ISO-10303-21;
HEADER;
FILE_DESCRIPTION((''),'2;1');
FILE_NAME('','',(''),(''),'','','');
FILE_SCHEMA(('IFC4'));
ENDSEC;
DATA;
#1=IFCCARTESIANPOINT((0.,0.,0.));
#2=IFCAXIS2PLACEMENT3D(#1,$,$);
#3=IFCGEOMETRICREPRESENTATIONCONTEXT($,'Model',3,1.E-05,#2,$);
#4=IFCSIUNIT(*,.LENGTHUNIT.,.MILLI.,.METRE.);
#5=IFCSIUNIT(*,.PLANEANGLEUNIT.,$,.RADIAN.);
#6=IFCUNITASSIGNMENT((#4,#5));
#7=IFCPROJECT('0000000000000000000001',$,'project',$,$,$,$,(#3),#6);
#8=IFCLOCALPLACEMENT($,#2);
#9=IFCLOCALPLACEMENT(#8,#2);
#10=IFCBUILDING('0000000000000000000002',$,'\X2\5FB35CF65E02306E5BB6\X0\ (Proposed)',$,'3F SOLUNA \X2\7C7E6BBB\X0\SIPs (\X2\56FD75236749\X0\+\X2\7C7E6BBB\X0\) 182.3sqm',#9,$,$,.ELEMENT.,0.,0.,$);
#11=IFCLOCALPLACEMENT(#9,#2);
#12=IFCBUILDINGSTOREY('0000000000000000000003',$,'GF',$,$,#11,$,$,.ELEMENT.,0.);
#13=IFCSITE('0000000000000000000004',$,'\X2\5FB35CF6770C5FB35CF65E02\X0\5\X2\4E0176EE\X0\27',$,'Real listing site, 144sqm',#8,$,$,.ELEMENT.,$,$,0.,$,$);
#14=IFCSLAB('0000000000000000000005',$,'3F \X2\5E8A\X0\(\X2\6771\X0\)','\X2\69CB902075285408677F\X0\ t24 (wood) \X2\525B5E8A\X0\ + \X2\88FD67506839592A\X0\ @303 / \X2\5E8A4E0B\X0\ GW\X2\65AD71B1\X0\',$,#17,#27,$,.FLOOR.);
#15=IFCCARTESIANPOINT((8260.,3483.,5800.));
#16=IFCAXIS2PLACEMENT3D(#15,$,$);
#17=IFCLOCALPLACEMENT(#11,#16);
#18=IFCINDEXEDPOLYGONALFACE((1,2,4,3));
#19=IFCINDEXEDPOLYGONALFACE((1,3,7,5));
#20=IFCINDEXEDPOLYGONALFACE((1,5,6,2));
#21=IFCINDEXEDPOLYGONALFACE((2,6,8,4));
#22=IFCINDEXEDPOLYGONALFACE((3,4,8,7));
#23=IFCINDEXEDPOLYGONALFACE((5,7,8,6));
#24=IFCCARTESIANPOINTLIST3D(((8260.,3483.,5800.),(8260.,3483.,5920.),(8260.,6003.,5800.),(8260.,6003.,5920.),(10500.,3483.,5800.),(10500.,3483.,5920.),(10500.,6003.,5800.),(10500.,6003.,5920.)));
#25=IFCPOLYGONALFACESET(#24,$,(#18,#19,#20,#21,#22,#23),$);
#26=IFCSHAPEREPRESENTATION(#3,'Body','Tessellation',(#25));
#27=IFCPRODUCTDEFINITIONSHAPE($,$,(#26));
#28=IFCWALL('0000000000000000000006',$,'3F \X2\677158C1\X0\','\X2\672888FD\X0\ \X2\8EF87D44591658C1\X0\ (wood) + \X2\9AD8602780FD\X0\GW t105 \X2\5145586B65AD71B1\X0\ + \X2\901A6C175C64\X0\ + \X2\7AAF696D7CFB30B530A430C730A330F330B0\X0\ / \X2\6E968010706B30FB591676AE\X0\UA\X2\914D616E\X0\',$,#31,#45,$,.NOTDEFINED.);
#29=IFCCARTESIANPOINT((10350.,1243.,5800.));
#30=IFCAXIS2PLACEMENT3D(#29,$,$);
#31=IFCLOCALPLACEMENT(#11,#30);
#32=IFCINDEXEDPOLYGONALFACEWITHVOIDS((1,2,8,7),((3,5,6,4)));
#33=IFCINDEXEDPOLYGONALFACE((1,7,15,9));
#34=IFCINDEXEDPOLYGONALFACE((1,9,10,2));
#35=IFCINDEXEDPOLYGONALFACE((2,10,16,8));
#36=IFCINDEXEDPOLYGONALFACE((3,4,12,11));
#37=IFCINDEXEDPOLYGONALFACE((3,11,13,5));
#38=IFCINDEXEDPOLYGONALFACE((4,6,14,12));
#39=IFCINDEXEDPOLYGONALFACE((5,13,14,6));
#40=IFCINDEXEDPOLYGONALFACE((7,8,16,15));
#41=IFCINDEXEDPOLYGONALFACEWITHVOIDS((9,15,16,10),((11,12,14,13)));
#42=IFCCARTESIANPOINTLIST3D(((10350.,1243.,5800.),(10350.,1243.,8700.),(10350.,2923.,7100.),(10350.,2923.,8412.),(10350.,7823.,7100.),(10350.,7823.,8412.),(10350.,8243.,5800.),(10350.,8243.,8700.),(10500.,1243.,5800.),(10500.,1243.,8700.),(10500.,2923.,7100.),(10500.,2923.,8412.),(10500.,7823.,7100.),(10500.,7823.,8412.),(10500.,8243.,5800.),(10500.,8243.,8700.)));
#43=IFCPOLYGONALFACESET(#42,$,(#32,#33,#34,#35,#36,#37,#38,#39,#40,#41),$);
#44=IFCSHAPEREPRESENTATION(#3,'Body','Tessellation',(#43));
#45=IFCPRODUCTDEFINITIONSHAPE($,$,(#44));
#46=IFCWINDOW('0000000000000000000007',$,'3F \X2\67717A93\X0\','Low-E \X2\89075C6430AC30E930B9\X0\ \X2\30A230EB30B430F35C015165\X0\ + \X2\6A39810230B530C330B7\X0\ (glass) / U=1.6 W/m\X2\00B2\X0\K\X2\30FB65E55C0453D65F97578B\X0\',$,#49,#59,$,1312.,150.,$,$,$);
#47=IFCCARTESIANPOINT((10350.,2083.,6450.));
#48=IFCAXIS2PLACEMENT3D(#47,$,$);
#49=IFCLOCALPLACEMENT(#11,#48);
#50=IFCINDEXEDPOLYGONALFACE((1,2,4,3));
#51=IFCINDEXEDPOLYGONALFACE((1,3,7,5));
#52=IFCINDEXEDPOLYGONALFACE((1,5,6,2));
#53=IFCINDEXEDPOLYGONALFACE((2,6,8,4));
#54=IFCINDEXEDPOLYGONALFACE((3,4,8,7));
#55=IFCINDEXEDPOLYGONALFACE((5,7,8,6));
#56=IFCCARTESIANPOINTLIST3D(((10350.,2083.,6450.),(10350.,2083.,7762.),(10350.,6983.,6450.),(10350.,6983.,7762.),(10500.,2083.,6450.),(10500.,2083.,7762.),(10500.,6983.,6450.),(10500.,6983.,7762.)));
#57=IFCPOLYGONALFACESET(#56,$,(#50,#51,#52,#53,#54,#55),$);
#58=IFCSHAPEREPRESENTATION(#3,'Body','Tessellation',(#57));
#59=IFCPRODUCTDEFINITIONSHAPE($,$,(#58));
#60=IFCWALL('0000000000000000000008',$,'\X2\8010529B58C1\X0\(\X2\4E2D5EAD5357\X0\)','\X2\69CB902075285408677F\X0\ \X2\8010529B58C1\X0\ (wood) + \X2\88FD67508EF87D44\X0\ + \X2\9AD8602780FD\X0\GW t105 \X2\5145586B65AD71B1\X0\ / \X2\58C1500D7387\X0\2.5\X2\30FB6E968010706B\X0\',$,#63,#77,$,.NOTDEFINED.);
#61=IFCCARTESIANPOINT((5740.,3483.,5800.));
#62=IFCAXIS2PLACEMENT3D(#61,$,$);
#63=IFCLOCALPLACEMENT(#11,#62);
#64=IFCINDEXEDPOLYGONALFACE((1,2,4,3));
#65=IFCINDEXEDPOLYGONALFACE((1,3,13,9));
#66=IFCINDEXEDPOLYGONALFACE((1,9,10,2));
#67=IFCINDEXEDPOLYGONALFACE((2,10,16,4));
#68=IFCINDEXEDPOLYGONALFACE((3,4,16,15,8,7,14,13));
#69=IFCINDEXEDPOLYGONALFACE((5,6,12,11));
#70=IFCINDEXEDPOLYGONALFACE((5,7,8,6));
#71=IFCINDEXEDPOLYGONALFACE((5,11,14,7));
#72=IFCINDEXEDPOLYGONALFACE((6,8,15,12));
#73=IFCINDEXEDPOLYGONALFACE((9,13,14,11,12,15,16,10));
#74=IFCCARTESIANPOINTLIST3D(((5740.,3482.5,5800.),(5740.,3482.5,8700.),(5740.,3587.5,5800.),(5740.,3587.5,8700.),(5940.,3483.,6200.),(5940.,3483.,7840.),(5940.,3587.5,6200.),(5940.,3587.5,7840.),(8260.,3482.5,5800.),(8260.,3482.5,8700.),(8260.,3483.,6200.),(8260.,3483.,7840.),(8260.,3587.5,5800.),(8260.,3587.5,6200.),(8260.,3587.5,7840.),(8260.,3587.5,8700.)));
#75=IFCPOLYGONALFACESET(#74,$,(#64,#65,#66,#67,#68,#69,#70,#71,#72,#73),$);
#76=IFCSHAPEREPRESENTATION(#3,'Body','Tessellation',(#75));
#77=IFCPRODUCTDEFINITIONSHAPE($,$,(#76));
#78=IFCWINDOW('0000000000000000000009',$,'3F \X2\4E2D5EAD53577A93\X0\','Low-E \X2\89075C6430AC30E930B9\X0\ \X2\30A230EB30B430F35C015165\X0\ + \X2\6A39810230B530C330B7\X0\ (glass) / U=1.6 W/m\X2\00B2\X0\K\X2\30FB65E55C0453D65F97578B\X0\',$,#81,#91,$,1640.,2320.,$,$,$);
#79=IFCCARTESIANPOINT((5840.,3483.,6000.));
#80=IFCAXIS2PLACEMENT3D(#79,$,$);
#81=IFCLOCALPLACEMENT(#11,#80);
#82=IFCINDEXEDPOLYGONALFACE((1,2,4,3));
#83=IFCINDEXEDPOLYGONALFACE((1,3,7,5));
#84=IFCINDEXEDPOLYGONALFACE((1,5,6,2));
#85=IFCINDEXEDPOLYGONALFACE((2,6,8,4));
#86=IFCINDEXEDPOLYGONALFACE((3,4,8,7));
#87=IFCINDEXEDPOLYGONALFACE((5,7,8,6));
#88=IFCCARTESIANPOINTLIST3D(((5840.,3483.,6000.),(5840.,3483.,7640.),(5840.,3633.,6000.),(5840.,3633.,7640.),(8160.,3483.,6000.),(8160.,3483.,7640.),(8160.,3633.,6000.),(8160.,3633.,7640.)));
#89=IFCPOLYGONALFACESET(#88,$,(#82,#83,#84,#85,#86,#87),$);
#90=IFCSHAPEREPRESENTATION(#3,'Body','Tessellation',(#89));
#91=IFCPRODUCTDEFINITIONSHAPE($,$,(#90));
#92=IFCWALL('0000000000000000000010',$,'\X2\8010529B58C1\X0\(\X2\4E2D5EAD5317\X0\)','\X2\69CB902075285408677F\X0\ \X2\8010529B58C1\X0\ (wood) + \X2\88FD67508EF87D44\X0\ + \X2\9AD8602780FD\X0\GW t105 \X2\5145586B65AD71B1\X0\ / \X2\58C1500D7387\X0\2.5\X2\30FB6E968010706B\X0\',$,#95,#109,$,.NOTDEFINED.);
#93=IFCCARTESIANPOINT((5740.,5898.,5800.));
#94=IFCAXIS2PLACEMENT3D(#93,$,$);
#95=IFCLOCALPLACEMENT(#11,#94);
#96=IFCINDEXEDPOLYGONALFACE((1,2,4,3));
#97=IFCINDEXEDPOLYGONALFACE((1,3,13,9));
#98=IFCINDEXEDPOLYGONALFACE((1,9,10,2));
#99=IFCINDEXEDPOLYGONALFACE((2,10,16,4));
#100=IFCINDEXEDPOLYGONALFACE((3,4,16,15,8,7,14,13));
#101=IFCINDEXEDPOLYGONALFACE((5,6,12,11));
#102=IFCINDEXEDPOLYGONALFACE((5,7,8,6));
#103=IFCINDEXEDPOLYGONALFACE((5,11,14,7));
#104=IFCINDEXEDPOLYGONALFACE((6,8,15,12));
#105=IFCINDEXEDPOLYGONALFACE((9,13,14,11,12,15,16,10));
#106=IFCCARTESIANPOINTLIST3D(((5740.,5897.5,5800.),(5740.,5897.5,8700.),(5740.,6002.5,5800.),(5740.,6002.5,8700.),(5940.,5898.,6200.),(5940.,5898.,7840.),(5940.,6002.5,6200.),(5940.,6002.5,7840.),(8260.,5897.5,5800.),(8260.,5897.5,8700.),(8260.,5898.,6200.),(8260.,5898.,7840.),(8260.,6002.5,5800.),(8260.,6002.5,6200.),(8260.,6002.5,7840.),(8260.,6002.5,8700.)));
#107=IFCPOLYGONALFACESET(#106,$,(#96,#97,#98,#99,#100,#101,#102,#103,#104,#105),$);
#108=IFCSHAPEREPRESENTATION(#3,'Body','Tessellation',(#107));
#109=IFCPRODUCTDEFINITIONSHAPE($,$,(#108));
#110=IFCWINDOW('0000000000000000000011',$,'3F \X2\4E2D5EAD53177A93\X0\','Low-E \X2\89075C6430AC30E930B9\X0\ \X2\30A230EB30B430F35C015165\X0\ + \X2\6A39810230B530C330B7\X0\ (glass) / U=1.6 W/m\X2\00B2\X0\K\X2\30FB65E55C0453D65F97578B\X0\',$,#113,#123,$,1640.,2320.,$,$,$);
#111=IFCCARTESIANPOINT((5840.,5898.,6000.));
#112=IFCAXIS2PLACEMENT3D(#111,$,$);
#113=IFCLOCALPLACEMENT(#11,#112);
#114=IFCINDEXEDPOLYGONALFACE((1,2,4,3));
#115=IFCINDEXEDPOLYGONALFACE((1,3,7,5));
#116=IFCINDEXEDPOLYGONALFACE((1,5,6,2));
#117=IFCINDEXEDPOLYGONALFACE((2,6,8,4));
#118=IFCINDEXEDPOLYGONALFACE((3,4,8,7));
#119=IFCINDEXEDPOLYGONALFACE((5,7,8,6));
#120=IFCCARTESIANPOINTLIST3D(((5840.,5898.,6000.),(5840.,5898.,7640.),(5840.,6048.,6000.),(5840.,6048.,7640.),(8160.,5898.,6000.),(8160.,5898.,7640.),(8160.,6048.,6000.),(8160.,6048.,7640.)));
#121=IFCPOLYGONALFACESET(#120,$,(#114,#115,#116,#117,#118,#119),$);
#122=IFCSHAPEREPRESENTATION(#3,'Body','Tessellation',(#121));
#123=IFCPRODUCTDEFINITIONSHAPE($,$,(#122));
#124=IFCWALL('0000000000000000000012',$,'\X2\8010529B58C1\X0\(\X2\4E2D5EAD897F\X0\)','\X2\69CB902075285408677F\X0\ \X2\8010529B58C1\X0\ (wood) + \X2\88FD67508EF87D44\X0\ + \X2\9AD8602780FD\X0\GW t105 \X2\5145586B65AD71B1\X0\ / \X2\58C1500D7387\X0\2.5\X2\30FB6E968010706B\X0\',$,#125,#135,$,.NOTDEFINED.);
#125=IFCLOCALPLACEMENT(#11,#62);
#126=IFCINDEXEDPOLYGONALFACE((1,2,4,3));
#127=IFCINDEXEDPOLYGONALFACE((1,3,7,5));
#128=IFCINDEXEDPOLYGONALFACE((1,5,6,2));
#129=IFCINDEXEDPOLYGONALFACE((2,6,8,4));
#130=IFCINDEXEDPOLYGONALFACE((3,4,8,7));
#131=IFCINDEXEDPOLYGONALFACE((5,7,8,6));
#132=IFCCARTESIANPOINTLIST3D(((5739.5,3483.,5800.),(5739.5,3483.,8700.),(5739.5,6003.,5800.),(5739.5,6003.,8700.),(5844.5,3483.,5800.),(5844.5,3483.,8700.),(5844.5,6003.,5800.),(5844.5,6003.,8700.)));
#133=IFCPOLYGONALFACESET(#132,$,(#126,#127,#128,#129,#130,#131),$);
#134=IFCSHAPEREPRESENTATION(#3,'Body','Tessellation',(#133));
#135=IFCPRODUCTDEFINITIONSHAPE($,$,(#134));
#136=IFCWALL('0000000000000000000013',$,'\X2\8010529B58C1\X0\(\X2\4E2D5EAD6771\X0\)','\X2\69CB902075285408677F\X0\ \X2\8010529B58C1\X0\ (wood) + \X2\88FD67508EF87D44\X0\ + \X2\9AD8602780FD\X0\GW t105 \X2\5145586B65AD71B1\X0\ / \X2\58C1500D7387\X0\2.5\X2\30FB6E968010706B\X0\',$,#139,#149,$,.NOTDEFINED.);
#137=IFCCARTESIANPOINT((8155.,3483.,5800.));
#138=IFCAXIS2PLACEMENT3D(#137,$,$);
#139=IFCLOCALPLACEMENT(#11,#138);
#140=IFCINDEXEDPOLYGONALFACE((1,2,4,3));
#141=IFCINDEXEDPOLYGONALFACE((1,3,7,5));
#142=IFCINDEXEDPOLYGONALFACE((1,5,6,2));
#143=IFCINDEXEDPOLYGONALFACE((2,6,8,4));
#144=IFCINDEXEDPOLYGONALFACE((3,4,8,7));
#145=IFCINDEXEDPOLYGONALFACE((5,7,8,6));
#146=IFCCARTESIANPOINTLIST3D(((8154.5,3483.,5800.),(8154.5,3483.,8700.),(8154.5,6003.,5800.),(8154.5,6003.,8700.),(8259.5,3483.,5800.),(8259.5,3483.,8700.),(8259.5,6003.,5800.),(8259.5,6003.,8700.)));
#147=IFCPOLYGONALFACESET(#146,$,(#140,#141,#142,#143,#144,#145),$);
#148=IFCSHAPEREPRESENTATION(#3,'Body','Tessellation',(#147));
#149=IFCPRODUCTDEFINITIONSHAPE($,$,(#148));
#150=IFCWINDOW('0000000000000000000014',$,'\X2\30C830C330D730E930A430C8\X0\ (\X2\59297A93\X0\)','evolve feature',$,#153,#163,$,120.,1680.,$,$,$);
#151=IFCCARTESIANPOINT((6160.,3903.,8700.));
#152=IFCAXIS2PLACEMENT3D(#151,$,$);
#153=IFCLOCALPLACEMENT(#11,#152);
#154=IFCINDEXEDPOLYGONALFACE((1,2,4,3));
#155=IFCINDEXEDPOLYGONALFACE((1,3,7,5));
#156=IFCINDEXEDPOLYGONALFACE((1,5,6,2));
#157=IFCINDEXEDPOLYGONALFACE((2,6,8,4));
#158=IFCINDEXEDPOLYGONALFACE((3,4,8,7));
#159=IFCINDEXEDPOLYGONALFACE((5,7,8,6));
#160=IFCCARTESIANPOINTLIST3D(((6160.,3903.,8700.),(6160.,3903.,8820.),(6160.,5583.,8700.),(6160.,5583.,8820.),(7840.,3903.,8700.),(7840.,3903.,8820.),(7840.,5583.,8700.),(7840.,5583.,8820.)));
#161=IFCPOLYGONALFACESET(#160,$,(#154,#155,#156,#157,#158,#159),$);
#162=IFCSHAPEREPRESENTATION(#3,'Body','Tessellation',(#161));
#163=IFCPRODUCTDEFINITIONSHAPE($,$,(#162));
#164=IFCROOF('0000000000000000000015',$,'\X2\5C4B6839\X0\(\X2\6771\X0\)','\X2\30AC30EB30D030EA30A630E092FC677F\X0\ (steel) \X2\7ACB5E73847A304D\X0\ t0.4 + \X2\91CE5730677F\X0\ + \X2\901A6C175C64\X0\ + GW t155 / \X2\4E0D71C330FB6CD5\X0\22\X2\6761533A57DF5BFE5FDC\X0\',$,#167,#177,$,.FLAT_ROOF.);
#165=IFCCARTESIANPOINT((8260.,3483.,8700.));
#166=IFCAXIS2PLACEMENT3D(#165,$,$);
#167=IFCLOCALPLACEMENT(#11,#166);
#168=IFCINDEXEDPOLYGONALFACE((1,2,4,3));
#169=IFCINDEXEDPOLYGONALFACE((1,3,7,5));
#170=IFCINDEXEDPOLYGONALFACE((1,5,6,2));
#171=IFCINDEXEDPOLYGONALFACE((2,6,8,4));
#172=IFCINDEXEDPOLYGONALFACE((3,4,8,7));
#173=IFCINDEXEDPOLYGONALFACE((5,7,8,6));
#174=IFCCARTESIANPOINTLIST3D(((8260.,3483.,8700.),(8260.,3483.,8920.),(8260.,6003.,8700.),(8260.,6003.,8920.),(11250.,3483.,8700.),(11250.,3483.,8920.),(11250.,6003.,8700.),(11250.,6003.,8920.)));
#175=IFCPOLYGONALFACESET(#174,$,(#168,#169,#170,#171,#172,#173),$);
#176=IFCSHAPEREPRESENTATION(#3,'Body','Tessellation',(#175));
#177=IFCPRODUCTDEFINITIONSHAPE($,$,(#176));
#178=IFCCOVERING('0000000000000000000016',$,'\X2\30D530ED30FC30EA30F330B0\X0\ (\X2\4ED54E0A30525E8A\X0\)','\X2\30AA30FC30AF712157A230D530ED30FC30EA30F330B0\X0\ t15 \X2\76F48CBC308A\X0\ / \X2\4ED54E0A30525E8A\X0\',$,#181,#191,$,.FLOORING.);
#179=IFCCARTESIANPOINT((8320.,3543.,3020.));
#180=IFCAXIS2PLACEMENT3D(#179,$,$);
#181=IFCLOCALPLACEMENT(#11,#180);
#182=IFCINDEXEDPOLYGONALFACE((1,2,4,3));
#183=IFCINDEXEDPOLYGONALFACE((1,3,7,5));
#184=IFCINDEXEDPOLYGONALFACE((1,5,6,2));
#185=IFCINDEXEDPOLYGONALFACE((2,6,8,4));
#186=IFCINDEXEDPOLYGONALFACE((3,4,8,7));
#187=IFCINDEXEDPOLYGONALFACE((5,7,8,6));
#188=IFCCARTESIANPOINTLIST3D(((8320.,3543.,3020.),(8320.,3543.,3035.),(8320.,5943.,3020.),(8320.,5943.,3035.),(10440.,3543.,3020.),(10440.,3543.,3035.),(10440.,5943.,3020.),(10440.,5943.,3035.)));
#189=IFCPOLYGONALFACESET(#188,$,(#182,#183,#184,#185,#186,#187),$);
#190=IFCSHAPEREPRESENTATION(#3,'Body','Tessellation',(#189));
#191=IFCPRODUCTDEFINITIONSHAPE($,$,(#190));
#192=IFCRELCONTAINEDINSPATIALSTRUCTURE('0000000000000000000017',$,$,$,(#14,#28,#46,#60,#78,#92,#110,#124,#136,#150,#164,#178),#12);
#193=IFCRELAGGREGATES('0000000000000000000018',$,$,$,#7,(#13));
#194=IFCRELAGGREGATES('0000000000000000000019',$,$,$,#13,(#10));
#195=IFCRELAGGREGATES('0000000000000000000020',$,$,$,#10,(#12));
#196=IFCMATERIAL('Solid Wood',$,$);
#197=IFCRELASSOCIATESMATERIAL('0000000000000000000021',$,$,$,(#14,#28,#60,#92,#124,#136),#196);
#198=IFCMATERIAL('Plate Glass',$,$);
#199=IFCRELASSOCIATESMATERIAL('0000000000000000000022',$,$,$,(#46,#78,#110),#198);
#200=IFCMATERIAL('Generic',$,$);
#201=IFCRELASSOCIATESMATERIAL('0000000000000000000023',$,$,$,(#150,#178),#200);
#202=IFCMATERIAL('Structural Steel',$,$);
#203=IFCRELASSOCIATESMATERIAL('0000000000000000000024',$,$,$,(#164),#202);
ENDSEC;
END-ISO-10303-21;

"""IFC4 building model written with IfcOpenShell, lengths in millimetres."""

from ifc_helpers import new_model, si_unit, frame, frame_2d, origin, place, context, project, spatial, rectangle, extrude, material, element, fill, save


model = new_model("IFC4")

# Units and contexts
model_context = context("Model", 3, precision=1e-05, world=origin())
ifc_project = project(units=[si_unit("LENGTHUNIT", "METRE", prefix="MILLI"), si_unit("PLANEANGLEUNIT", "RADIAN")], contexts=[model_context])

# Site, building, storey
site_placement = place(None, origin())
site = spatial("IfcSite", under=ifc_project, at=site_placement, Name="徳島県徳島市5丁目27", ObjectType="Real listing site, 144sqm", CompositionType="ELEMENT", RefElevation=0.0)
building_placement = place(site_placement, origin())
building = spatial("IfcBuilding", under=site, at=building_placement, Name="徳島市の家 (Proposed)", ObjectType="3F SOLUNA 籾殻SIPs (国産杉+籾殻) 182.3sqm", CompositionType="ELEMENT", ElevationOfRefHeight=0.0, ElevationOfTerrain=0.0)
storey_placement = place(building_placement, origin())
storey = spatial("IfcBuildingStorey", under=building, at=storey_placement, Name="GF", CompositionType="ELEMENT", Elevation=0.0)

# Slab
ifc_material_1 = material(Name="Solid Wood")
slab_placement = place(storey_placement, frame((8260.0, 3483.0, 5800.0)))
element("IfcSlab", 1, at=slab_placement, inside=storey, material=ifc_material_1, Name="3F 床(東)", Description="構造用合板 t24 (wood) 剛床 + 製材根太 @303 / 床下 GW断熱", PredefinedType="FLOOR", context=model_context, shape_type="SweptSolid", body=[
    extrude(rectangle(XDim=2240.0, YDim=2520.0, at=frame_2d((1120.0, 1260.0))), frame((8260.0, 3483.0, 5800.0)), (0.0, 0.0, 1.0), 120.0),
])

# Walls, openings, windows
wall_1_placement = place(storey_placement, frame((10350.0, 1243.0, 5800.0)))
wall_1 = element("IfcWall", 2, at=wall_1_placement, inside=storey, material=ifc_material_1, Name="3F 東壁", Description="木製 軸組外壁 (wood) + 高性能GW t105 充填断熱 + 通気層 + 窯業系サイディング / 準耐火・外皮UA配慮", PredefinedType="NOTDEFINED", context=model_context, shape_type="SweptSolid", body=[
    extrude(rectangle(XDim=150.0, YDim=7000.0, at=frame_2d((75.0, 3500.0))), frame((10350.0, 1243.0, 5800.0)), (0.0, 0.0, 1.0), 2900.0),
])
opening_1_placement = place(storey_placement, frame((10350.0, 2083.0, 6450.0)))
opening_1 = element("IfcOpeningElement", 3, at=opening_1_placement, cuts=wall_1, PredefinedType="NOTDEFINED", context=model_context, shape_type="SweptSolid", body=[
    extrude(rectangle(XDim=150.0, YDim=4900.0, at=frame_2d((75.0, 2450.0))), frame((10350.0, 2083.0, 6450.0)), (0.0, 0.0, 1.0), 1312.0),
])
ifc_material_2 = material(Name="Plate Glass")
window_1_placement = place(storey_placement, frame((10350.0, 2083.0, 6450.0)))
window_1 = element("IfcWindow", 4, at=window_1_placement, inside=storey, material=ifc_material_2, Name="3F 東窓", Description="Low-E 複層ガラス アルゴン封入 + 樹脂サッシ (glass) / U=1.6 W/m²K・日射取得型", OverallHeight=1312.0, OverallWidth=150.0, context=model_context, shape_type="SweptSolid", body=[
    extrude(rectangle(XDim=150.0, YDim=4900.0, at=frame_2d((75.0, 2450.0))), frame((10350.0, 2083.0, 6450.0)), (0.0, 0.0, 1.0), 1312.0),
])
fill(opening_1, window_1)
wall_2_placement = place(storey_placement, frame((5740.0, 3483.0, 5800.0)))
wall_2 = element("IfcWall", 5, at=wall_2_placement, inside=storey, material=ifc_material_1, Name="耐力壁(中庭南)", Description="構造用合板 耐力壁 (wood) + 製材軸組 + 高性能GW t105 充填断熱 / 壁倍率2.5・準耐火", PredefinedType="NOTDEFINED", context=model_context, shape_type="SweptSolid", body=[
    extrude(rectangle(XDim=2520.0, YDim=105.0, at=frame_2d((1260.0, 52.0))), frame((5740.0, 3483.0, 5800.0)), (0.0, 0.0, 1.0), 2900.0),
])
opening_2_placement = place(storey_placement, frame((5840.0, 3483.0, 6000.0)))
opening_2 = element("IfcOpeningElement", 6, at=opening_2_placement, cuts=wall_2, PredefinedType="NOTDEFINED", context=model_context, shape_type="SweptSolid", body=[
    extrude(rectangle(XDim=2320.0, YDim=150.0, at=frame_2d((1160.0, 75.0))), frame((5840.0, 3483.0, 6000.0)), (0.0, 0.0, 1.0), 1640.0),
])
window_2_placement = place(storey_placement, frame((5840.0, 3483.0, 6000.0)))
window_2 = element("IfcWindow", 7, at=window_2_placement, inside=storey, material=ifc_material_2, Name="3F 中庭南窓", Description="Low-E 複層ガラス アルゴン封入 + 樹脂サッシ (glass) / U=1.6 W/m²K・日射取得型", OverallHeight=1640.0, OverallWidth=2320.0, context=model_context, shape_type="SweptSolid", body=[
    extrude(rectangle(XDim=2320.0, YDim=150.0, at=frame_2d((1160.0, 75.0))), frame((5840.0, 3483.0, 6000.0)), (0.0, 0.0, 1.0), 1640.0),
])
fill(opening_2, window_2)
wall_3_placement = place(storey_placement, frame((5740.0, 5898.0, 5800.0)))
wall_3 = element("IfcWall", 8, at=wall_3_placement, inside=storey, material=ifc_material_1, Name="耐力壁(中庭北)", Description="構造用合板 耐力壁 (wood) + 製材軸組 + 高性能GW t105 充填断熱 / 壁倍率2.5・準耐火", PredefinedType="NOTDEFINED", context=model_context, shape_type="SweptSolid", body=[
    extrude(rectangle(XDim=2520.0, YDim=105.0, at=frame_2d((1260.0, 52.0))), frame((5740.0, 5898.0, 5800.0)), (0.0, 0.0, 1.0), 2900.0),
])
opening_3_placement = place(storey_placement, frame((5840.0, 5898.0, 6000.0)))
opening_3 = element("IfcOpeningElement", 9, at=opening_3_placement, cuts=wall_3, PredefinedType="NOTDEFINED", context=model_context, shape_type="SweptSolid", body=[
    extrude(rectangle(XDim=2320.0, YDim=150.0, at=frame_2d((1160.0, 75.0))), frame((5840.0, 5898.0, 6000.0)), (0.0, 0.0, 1.0), 1640.0),
])
window_3_placement = place(storey_placement, frame((5840.0, 5898.0, 6000.0)))
window_3 = element("IfcWindow", 10, at=window_3_placement, inside=storey, material=ifc_material_2, Name="3F 中庭北窓", Description="Low-E 複層ガラス アルゴン封入 + 樹脂サッシ (glass) / U=1.6 W/m²K・日射取得型", OverallHeight=1640.0, OverallWidth=2320.0, context=model_context, shape_type="SweptSolid", body=[
    extrude(rectangle(XDim=2320.0, YDim=150.0, at=frame_2d((1160.0, 75.0))), frame((5840.0, 5898.0, 6000.0)), (0.0, 0.0, 1.0), 1640.0),
])
fill(opening_3, window_3)

# Walls
wall_4_placement = place(storey_placement, frame((5740.0, 3483.0, 5800.0)))
element("IfcWall", 11, at=wall_4_placement, inside=storey, material=ifc_material_1, Name="耐力壁(中庭西)", Description="構造用合板 耐力壁 (wood) + 製材軸組 + 高性能GW t105 充填断熱 / 壁倍率2.5・準耐火", PredefinedType="NOTDEFINED", context=model_context, shape_type="SweptSolid", body=[
    extrude(rectangle(XDim=105.0, YDim=2520.0, at=frame_2d((52.0, 1260.0))), frame((5740.0, 3483.0, 5800.0)), (0.0, 0.0, 1.0), 2900.0),
])
wall_5_placement = place(storey_placement, frame((8155.0, 3483.0, 5800.0)))
element("IfcWall", 12, at=wall_5_placement, inside=storey, material=ifc_material_1, Name="耐力壁(中庭東)", Description="構造用合板 耐力壁 (wood) + 製材軸組 + 高性能GW t105 充填断熱 / 壁倍率2.5・準耐火", PredefinedType="NOTDEFINED", context=model_context, shape_type="SweptSolid", body=[
    extrude(rectangle(XDim=105.0, YDim=2520.0, at=frame_2d((52.0, 1260.0))), frame((8155.0, 3483.0, 5800.0)), (0.0, 0.0, 1.0), 2900.0),
])

# Window
ifc_material_3 = material(Name="Generic")
window_4_placement = place(storey_placement, frame((6160.0, 3903.0, 8700.0)))
element("IfcWindow", 13, at=window_4_placement, inside=storey, material=ifc_material_3, Name="トップライト (天窓)", Description="evolve feature", OverallHeight=120.0, OverallWidth=1680.0, context=model_context, shape_type="SweptSolid", body=[
    extrude(rectangle(XDim=1680.0, YDim=1680.0, at=frame_2d((840.0, 840.0))), frame((6160.0, 3903.0, 8700.0)), (0.0, 0.0, 1.0), 120.0),
])

# Roof
ifc_material_4 = material(Name="Structural Steel")
for number, where, name in (
    (14, (8260.0, 3483.0, 8700.0), "屋根(東)"),
):
    element("IfcRoof", number, at=place(storey_placement, frame(where)), inside=storey, material=ifc_material_4, Name=name, Description="ガルバリウム鋼板 (steel) 立平葺き t0.4 + 野地板 + 通気層 + GW t155 / 不燃・法22条区域対応", PredefinedType="FLAT_ROOF", context=model_context, shape_type="SweptSolid", body=[
        extrude(rectangle(XDim=2990.0, YDim=2520.0, at=frame_2d((1495.0, 1260.0))), frame((8260.0, 3483.0, 8700.0)), (0.0, 0.0, 1.0), 220.0),
    ])

# Covering
covering_1_placement = place(storey_placement, frame((8320.0, 3543.0, 3020.0)))
element("IfcCovering", 15, at=covering_1_placement, inside=storey, material=ifc_material_3, Name="フローリング (仕上げ床)", Description="オーク無垢フローリング t15 直貼り / 仕上げ床", PredefinedType="FLOORING", context=model_context, shape_type="SweptSolid", body=[
    extrude(rectangle(XDim=2120.0, YDim=2400.0, at=frame_2d((1060.0, 1200.0))), frame((8320.0, 3543.0, 3020.0)), (0.0, 0.0, 1.0), 15.0),
])

save(model, "model.ifc")
